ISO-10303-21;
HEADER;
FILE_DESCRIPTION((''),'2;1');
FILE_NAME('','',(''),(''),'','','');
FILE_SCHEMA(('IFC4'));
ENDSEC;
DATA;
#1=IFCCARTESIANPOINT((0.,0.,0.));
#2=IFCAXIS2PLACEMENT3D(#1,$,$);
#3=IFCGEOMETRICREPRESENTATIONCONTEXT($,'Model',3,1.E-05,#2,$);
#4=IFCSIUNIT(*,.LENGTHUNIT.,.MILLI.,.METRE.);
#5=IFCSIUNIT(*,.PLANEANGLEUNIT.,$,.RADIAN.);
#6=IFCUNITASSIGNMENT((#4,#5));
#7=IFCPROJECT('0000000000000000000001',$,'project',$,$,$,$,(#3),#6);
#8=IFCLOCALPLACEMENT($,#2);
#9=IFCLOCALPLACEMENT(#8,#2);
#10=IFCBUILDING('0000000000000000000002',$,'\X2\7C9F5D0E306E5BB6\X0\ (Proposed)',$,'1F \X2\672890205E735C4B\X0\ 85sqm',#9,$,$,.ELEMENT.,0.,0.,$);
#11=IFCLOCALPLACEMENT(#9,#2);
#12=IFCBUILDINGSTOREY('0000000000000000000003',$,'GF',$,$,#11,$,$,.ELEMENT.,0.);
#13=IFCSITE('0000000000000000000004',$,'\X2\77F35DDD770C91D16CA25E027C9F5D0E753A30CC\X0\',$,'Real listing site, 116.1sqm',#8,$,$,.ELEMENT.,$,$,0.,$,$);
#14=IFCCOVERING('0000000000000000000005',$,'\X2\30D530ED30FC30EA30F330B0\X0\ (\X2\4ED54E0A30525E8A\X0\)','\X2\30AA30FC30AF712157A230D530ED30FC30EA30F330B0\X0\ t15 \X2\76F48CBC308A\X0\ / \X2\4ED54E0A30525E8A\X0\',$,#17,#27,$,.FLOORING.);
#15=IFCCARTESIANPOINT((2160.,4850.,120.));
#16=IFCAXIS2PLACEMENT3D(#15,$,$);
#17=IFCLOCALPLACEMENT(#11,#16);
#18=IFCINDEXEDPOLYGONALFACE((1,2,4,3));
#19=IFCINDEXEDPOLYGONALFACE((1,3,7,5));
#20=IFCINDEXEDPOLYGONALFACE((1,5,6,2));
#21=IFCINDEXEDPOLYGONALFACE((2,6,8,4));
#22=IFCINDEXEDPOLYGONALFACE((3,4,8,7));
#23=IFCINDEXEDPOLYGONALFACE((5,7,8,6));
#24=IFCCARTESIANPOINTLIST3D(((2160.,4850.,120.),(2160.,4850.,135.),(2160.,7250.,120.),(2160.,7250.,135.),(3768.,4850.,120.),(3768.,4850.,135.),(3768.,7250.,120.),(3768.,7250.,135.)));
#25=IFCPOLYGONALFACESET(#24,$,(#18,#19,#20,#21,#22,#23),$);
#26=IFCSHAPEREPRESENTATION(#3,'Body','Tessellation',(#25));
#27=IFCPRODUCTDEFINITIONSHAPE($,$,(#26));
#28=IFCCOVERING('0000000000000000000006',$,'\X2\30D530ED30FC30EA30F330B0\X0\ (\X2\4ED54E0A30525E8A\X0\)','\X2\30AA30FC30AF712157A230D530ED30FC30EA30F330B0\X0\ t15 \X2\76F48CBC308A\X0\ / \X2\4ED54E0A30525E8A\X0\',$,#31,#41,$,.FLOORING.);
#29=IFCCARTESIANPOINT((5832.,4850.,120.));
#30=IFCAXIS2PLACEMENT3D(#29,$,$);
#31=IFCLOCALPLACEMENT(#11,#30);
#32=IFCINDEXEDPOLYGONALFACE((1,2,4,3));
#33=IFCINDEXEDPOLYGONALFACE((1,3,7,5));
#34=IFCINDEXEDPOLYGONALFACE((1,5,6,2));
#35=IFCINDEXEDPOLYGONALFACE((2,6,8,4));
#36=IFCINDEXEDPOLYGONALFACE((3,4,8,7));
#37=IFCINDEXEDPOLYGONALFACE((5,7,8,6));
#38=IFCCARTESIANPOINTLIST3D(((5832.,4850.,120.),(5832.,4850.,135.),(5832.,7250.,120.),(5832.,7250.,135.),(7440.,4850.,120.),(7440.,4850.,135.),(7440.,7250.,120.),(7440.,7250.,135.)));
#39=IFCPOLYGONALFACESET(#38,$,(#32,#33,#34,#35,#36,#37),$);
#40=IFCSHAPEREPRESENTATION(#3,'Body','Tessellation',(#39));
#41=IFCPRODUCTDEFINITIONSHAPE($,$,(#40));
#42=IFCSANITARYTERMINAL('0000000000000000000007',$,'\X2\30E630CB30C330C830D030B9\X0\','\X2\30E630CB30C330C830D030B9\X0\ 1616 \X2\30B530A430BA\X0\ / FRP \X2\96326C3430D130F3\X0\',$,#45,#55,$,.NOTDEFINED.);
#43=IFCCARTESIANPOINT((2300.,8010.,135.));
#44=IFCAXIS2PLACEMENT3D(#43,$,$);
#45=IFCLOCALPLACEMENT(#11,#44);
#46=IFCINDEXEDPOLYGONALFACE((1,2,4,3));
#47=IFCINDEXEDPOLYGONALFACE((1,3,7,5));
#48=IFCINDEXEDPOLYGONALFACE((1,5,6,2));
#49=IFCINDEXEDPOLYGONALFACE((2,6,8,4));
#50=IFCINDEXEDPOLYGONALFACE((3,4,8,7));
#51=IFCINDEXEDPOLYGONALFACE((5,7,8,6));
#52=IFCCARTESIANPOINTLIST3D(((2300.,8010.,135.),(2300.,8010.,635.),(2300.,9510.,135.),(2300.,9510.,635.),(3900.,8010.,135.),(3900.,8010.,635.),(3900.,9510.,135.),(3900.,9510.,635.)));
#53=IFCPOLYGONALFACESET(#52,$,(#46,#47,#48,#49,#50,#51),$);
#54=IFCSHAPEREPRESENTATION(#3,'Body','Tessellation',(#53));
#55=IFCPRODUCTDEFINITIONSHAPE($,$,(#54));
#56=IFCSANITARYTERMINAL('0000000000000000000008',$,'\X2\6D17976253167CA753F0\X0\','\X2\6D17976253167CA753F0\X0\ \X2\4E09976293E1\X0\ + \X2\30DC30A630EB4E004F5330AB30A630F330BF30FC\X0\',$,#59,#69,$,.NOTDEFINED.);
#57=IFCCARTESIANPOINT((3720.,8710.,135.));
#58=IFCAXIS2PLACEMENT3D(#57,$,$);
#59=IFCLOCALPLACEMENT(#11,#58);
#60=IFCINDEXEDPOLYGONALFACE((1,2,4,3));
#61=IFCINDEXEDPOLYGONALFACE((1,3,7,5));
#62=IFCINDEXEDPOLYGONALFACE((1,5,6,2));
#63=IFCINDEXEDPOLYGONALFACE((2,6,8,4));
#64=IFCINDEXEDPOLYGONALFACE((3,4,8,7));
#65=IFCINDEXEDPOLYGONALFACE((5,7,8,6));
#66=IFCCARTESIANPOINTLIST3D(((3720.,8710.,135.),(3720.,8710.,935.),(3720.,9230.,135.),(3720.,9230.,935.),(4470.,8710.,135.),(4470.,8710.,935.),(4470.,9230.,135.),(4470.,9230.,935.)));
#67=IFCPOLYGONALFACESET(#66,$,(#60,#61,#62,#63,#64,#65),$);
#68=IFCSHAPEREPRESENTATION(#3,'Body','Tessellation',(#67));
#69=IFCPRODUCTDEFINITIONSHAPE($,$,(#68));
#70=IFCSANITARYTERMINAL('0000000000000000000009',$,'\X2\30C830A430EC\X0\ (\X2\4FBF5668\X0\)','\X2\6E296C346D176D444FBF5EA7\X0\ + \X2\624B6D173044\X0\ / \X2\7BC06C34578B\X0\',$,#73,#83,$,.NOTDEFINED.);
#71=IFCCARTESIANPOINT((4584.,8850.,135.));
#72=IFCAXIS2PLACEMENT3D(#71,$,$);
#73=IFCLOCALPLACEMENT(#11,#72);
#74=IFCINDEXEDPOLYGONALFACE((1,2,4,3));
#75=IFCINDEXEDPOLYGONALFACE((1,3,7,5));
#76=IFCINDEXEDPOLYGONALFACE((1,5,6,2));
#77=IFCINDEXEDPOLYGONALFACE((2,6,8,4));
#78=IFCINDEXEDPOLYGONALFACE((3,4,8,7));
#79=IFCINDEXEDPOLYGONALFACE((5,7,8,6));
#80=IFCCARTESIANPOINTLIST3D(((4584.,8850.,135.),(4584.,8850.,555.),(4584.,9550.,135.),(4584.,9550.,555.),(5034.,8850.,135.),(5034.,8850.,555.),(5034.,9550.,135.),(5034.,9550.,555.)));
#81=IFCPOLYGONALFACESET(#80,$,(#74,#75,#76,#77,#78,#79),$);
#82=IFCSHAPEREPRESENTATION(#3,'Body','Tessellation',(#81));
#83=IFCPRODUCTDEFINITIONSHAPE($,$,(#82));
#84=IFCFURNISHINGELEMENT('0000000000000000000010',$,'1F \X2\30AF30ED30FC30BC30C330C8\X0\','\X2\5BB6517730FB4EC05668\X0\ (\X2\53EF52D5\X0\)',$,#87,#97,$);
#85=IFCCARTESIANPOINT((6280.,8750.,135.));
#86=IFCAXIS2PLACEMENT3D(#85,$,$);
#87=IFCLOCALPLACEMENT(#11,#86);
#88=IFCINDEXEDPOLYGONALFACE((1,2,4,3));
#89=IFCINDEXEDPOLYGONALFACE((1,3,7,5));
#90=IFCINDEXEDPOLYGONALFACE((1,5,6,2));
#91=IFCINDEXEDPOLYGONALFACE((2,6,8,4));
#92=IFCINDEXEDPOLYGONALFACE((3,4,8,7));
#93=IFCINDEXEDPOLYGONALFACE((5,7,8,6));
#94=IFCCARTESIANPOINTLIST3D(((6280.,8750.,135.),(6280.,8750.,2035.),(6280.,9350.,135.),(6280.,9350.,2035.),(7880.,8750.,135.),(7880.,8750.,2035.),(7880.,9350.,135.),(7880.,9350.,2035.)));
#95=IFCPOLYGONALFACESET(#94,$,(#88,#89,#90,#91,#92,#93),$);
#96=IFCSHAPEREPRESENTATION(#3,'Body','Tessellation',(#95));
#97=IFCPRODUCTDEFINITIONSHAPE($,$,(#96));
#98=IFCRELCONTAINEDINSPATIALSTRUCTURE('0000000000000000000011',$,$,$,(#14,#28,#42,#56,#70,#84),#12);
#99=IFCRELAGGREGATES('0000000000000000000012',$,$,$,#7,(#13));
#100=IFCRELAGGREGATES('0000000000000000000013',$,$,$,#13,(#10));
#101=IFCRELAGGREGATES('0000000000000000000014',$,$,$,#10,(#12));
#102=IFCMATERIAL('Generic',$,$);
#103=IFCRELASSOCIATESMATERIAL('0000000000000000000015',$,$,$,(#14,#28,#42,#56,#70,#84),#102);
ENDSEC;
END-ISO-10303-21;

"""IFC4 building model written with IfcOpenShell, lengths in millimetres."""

from ifc_helpers import new_model, si_unit, frame, frame_2d, origin, place, context, project, spatial, rectangle, extrude, material, element, save


model = new_model("IFC4")

# Units and contexts
model_context = context("Model", 3, precision=1e-05, world=origin())
ifc_project = project(units=[si_unit("LENGTHUNIT", "METRE", prefix="MILLI"), si_unit("PLANEANGLEUNIT", "RADIAN")], contexts=[model_context])

# Site, building, storey
site_placement = place(None, origin())
site = spatial("IfcSite", under=ifc_project, at=site_placement, Name="石川県金沢市粟崎町ヌ", ObjectType="Real listing site, 116.1sqm", CompositionType="ELEMENT", RefElevation=0.0)
building_placement = place(site_placement, origin())
building = spatial("IfcBuilding", under=site, at=building_placement, Name="粟崎の家 (Proposed)", ObjectType="1F 木造平屋 85sqm", CompositionType="ELEMENT", ElevationOfRefHeight=0.0, ElevationOfTerrain=0.0)
storey_placement = place(building_placement, origin())
storey = spatial("IfcBuildingStorey", under=building, at=storey_placement, Name="GF", CompositionType="ELEMENT", Elevation=0.0)

# Coverings
ifc_material_1 = material(Name="Generic")
covering_1_placement = place(storey_placement, frame((2160.0, 4850.0, 120.0)))
element("IfcCovering", 1, at=covering_1_placement, inside=storey, material=ifc_material_1, Name="フローリング (仕上げ床)", Description="オーク無垢フローリング t15 直貼り / 仕上げ床", PredefinedType="FLOORING", context=model_context, shape_type="SweptSolid", body=[
    extrude(rectangle(XDim=1608.0, YDim=2400.0, at=frame_2d((804.0, 1200.0))), frame((2160.0, 4850.0, 120.0)), (0.0, 0.0, 1.0), 15.0),
])
covering_2_placement = place(storey_placement, frame((5832.0, 4850.0, 120.0)))
element("IfcCovering", 2, at=covering_2_placement, inside=storey, material=ifc_material_1, Name="フローリング (仕上げ床)", Description="オーク無垢フローリング t15 直貼り / 仕上げ床", PredefinedType="FLOORING", context=model_context, shape_type="SweptSolid", body=[
    extrude(rectangle(XDim=1608.0, YDim=2400.0, at=frame_2d((804.0, 1200.0))), frame((5832.0, 4850.0, 120.0)), (0.0, 0.0, 1.0), 15.0),
])

# Sanitary terminals
sanitary_terminal_1_placement = place(storey_placement, frame((2300.0, 8010.0, 135.0)))
element("IfcSanitaryTerminal", 3, at=sanitary_terminal_1_placement, inside=storey, material=ifc_material_1, Name="ユニットバス", Description="ユニットバス 1616 サイズ / FRP 防水パン", PredefinedType="NOTDEFINED", context=model_context, shape_type="SweptSolid", body=[
    extrude(rectangle(XDim=1600.0, YDim=1500.0, at=frame_2d((800.0, 750.0))), frame((2300.0, 8010.0, 135.0)), (0.0, 0.0, 1.0), 500.0),
])
sanitary_terminal_2_placement = place(storey_placement, frame((3720.0, 8710.0, 135.0)))
element("IfcSanitaryTerminal", 4, at=sanitary_terminal_2_placement, inside=storey, material=ifc_material_1, Name="洗面化粧台", Description="洗面化粧台 三面鏡 + ボウル一体カウンター", PredefinedType="NOTDEFINED", context=model_context, shape_type="SweptSolid", body=[
    extrude(rectangle(XDim=750.0, YDim=520.0, at=frame_2d((375.0, 260.0))), frame((3720.0, 8710.0, 135.0)), (0.0, 0.0, 1.0), 800.0),
])
sanitary_terminal_3_placement = place(storey_placement, frame((4584.0, 8850.0, 135.0)))
element("IfcSanitaryTerminal", 5, at=sanitary_terminal_3_placement, inside=storey, material=ifc_material_1, Name="トイレ (便器)", Description="温水洗浄便座 + 手洗い / 節水型", PredefinedType="NOTDEFINED", context=model_context, shape_type="SweptSolid", body=[
    extrude(rectangle(XDim=450.0, YDim=700.0, at=frame_2d((225.0, 350.0))), frame((4584.0, 8850.0, 135.0)), (0.0, 0.0, 1.0), 420.0),
])

# Furnishing element
furnishing_placement = place(storey_placement, frame((6280.0, 8750.0, 135.0)))
element("IfcFurnishingElement", 6, at=furnishing_placement, inside=storey, material=ifc_material_1, Name="1F クローゼット", Description="家具・什器 (可動)", context=model_context, shape_type="SweptSolid", body=[
    extrude(rectangle(XDim=1600.0, YDim=600.0, at=frame_2d((800.0, 300.0))), frame((6280.0, 8750.0, 135.0)), (0.0, 0.0, 1.0), 1900.0),
])

save(model, "model.ifc")
